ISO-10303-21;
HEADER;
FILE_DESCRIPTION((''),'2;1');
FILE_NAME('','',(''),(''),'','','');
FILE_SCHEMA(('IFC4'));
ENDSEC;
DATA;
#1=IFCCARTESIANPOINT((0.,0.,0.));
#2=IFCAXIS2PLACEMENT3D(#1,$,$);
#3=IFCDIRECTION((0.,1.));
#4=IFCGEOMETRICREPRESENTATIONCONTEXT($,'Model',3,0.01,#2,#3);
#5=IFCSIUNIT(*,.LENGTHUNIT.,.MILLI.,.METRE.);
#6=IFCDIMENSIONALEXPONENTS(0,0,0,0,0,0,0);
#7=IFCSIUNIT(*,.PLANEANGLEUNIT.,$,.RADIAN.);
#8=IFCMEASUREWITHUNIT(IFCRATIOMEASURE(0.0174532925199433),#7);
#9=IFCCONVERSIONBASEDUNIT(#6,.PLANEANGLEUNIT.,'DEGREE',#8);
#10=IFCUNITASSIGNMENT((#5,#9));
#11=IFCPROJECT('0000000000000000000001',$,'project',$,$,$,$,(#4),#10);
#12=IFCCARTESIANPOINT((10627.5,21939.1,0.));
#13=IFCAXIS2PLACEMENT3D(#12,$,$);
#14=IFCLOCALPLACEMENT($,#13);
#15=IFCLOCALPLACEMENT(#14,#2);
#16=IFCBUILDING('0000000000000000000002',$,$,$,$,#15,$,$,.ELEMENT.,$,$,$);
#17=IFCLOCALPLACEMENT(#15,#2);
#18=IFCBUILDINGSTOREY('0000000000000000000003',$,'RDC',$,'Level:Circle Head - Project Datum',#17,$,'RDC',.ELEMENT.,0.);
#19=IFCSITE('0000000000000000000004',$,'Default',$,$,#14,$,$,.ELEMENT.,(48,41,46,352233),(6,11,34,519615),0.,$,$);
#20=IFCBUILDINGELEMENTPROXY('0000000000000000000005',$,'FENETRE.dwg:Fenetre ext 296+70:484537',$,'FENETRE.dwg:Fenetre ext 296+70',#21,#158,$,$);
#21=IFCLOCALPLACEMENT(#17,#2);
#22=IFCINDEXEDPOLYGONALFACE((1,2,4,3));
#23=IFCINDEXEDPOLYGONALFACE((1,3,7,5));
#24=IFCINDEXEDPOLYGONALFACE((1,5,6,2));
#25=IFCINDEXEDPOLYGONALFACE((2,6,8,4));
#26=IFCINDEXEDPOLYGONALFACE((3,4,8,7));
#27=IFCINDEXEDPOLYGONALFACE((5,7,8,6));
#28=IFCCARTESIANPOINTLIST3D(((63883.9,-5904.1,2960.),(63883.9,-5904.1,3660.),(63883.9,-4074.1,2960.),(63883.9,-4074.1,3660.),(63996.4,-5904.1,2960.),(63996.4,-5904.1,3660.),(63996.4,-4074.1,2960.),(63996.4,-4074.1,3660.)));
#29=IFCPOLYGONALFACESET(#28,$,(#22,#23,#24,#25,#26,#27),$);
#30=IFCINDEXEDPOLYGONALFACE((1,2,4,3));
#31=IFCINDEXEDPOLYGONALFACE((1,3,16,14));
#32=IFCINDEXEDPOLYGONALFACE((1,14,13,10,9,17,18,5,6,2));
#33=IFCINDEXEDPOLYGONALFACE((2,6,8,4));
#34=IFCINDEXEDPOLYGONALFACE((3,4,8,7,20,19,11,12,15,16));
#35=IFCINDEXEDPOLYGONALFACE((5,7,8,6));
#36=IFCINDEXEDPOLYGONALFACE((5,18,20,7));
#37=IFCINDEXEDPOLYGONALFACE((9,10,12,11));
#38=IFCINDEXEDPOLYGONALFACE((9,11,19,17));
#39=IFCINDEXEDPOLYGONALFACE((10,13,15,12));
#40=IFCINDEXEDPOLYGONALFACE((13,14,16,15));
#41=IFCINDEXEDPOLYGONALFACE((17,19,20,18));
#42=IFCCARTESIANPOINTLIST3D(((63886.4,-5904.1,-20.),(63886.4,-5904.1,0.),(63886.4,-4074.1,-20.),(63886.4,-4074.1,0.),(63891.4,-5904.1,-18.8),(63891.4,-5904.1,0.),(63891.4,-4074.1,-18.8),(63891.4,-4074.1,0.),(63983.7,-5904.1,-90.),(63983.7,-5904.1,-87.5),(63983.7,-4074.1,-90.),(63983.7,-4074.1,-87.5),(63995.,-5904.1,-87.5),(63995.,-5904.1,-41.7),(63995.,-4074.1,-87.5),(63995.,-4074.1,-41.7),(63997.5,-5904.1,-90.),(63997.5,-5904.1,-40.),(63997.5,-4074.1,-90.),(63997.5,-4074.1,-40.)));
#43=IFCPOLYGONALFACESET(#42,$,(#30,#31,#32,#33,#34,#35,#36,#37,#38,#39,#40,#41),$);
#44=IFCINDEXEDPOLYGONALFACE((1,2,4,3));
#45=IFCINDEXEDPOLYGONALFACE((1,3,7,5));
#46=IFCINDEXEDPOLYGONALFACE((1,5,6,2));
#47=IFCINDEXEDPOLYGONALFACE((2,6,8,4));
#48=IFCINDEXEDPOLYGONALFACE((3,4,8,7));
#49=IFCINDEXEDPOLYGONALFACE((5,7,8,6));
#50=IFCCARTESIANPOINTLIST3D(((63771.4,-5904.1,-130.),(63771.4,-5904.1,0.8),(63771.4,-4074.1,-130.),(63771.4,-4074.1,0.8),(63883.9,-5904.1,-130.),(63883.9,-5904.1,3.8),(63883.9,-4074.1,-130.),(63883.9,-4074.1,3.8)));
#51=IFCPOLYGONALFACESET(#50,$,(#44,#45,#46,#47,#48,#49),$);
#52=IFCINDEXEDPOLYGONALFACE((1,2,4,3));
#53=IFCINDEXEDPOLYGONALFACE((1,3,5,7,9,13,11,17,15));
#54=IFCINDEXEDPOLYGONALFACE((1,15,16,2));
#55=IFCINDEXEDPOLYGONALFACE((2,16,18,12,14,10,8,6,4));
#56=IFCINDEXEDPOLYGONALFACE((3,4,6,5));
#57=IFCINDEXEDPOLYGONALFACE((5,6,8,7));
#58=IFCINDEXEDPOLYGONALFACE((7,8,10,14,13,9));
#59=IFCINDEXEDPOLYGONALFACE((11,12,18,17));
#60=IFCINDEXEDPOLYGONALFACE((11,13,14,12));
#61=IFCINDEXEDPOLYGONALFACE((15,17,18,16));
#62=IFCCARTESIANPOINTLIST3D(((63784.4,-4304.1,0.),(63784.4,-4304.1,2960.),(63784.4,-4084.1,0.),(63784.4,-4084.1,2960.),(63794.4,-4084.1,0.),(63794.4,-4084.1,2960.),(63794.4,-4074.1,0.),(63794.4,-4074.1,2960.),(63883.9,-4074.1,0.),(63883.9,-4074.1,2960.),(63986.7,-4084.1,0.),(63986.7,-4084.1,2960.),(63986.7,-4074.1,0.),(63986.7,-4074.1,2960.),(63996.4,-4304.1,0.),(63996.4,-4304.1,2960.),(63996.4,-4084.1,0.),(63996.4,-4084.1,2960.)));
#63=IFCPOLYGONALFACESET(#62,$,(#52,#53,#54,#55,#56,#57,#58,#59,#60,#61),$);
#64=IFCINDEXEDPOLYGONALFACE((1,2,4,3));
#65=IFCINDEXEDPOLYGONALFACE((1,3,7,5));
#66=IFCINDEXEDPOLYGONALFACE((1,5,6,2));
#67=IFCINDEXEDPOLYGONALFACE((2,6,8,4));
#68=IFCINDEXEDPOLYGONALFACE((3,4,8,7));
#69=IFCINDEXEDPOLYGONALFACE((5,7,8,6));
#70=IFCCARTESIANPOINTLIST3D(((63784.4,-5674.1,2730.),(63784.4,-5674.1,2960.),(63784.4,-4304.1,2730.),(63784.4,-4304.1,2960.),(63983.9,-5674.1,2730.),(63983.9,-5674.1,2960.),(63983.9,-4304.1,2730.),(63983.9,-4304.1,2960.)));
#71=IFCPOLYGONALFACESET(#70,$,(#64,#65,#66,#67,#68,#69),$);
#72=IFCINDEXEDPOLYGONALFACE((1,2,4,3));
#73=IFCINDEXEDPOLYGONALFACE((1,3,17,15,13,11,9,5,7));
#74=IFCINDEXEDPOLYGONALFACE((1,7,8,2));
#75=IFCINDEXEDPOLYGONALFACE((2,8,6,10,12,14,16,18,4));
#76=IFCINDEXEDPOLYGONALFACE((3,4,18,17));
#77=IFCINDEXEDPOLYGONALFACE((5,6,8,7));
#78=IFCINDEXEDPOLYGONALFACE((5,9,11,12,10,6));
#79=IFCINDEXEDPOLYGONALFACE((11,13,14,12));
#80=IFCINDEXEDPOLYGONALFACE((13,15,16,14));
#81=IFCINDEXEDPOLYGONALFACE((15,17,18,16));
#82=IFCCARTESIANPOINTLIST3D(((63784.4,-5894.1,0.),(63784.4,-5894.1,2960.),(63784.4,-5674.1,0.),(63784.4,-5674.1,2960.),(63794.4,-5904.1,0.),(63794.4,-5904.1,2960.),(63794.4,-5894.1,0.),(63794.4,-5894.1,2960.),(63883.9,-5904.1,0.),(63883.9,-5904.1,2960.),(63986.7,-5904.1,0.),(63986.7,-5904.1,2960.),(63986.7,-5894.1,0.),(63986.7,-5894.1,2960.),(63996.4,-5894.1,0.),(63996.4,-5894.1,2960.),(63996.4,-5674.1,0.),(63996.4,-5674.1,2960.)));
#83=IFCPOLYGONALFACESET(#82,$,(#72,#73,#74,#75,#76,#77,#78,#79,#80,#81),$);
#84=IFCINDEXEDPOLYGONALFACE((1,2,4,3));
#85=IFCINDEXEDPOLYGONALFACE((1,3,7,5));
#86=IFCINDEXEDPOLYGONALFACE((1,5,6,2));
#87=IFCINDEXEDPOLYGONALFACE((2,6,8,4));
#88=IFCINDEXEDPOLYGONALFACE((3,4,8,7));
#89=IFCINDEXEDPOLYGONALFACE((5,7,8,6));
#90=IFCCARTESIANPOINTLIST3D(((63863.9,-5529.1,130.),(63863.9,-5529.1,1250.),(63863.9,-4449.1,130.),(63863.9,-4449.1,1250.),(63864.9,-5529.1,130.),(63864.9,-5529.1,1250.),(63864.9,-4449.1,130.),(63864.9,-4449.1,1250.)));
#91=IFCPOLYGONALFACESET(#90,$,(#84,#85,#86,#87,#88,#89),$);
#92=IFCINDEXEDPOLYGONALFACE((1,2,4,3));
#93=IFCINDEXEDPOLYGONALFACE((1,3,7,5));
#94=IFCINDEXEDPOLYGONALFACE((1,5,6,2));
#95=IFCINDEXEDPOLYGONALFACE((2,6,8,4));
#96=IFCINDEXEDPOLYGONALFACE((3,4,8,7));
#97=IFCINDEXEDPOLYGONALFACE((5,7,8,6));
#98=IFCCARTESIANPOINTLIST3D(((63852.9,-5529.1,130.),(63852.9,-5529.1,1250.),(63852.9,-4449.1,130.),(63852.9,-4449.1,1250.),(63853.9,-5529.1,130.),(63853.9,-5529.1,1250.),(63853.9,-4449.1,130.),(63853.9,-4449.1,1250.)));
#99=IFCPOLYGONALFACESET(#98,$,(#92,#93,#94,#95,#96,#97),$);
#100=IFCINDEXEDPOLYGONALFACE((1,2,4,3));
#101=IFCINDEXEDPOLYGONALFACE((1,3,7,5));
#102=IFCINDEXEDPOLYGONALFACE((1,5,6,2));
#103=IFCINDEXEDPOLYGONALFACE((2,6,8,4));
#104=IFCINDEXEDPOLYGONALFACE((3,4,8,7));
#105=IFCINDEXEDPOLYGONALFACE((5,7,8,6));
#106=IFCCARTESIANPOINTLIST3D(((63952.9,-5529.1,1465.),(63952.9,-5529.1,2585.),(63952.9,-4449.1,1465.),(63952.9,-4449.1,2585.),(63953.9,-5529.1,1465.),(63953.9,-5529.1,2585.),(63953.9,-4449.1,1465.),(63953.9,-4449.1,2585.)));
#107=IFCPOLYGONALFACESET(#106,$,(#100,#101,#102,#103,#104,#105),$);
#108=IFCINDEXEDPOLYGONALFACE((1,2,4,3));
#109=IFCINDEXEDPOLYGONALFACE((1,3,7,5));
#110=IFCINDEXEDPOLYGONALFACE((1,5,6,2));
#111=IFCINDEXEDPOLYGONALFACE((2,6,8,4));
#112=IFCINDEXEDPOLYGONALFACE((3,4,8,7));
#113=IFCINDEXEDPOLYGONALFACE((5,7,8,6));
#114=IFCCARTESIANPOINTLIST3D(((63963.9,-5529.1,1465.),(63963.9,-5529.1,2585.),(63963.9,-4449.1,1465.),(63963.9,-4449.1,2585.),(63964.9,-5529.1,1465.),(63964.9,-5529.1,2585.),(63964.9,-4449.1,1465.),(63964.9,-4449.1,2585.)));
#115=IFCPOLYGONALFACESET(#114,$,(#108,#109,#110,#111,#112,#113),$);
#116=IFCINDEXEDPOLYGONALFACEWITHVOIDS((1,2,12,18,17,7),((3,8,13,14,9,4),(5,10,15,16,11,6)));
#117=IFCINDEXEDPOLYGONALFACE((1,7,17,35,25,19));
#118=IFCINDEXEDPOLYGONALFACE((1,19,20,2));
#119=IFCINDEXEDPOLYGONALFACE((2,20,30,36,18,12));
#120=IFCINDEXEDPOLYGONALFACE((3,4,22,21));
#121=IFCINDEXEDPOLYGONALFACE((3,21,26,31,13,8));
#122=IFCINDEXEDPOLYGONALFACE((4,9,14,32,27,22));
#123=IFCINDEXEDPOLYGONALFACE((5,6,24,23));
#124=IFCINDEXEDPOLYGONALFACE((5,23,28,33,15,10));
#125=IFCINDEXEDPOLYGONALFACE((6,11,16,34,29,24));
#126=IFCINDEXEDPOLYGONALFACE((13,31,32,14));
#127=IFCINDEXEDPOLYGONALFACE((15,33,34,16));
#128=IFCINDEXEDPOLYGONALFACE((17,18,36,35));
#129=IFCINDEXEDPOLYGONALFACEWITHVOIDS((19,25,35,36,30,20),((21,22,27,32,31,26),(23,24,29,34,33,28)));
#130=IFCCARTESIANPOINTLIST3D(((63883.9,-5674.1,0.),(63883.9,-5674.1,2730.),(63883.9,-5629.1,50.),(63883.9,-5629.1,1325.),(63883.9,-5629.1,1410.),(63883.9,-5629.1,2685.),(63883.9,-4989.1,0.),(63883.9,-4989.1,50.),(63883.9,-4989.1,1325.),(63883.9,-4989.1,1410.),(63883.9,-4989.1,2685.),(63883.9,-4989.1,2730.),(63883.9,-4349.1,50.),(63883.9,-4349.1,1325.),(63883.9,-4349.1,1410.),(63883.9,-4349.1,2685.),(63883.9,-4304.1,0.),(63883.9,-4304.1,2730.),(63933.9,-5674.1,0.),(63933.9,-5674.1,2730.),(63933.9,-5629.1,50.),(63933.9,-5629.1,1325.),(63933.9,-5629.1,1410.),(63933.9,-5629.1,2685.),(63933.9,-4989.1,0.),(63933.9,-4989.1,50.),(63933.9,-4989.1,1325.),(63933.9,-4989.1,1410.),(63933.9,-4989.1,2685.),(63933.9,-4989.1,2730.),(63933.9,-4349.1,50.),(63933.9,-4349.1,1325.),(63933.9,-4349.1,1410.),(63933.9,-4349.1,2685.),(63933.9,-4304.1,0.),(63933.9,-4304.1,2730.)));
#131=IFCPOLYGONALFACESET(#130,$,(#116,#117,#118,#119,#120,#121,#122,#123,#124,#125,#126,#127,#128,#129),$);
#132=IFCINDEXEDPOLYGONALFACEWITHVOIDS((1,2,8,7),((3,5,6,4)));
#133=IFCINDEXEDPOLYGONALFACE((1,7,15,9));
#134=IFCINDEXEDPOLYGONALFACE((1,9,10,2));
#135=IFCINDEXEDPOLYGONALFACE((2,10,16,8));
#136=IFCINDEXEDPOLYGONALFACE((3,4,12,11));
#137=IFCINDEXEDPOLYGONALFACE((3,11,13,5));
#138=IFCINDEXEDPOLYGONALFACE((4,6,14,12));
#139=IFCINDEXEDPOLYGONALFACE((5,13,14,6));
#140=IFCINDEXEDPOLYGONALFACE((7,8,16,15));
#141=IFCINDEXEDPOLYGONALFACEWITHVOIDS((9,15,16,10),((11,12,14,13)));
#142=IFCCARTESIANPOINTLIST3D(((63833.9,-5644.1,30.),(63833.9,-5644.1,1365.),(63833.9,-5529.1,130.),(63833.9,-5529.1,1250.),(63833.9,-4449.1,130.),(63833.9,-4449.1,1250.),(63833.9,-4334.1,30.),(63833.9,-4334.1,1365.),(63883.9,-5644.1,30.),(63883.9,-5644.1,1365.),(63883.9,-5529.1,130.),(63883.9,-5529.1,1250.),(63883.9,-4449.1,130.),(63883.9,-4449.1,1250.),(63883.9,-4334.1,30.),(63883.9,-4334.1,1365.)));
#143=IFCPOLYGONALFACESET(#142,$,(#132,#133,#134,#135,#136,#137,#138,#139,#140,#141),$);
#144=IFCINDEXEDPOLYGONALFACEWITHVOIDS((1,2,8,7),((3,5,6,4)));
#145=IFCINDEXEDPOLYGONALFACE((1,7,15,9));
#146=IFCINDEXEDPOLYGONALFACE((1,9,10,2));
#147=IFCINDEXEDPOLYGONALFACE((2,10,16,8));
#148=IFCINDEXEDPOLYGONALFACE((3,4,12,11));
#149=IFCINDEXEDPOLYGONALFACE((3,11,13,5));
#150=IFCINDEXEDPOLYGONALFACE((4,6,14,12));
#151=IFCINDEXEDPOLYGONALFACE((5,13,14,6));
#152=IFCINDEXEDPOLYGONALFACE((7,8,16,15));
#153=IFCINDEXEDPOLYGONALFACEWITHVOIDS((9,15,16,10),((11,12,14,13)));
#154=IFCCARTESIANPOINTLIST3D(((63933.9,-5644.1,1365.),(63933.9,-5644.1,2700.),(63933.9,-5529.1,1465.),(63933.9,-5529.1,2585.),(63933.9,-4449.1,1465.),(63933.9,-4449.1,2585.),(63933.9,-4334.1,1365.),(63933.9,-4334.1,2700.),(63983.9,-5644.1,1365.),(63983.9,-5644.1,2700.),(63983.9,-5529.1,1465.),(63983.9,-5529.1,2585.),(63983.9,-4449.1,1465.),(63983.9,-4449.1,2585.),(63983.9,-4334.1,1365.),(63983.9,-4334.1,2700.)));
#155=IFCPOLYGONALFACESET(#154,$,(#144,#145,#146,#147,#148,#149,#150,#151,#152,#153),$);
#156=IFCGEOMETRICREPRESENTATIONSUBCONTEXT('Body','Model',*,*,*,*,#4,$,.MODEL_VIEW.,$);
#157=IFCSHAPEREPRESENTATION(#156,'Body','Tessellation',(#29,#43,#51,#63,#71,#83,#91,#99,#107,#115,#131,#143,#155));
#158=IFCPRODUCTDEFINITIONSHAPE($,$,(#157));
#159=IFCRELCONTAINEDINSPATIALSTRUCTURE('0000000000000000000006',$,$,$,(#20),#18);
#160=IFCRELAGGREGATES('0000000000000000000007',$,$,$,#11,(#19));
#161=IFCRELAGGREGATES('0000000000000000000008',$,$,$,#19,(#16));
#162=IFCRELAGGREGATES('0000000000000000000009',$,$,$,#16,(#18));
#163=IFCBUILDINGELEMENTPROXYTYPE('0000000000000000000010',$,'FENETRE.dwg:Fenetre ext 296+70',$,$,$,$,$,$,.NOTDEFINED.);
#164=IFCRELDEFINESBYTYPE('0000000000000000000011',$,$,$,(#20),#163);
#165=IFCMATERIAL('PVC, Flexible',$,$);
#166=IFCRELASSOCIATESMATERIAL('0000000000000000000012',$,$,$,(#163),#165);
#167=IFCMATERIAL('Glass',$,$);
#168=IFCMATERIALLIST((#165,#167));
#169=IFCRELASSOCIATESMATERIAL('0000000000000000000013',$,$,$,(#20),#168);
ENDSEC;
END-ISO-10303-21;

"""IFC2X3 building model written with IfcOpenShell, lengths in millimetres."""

from ifc_helpers import new_model, entity, si_unit, converted_unit, direction, frame, frame_2d, origin, origin_2d_with_axis, place, context, subcontext, project, spatial, polyline, rectangle, outline, extrude, source, transform, mapped, material, material_list, type_object, type_shapes, element, save


model = new_model("IFC2X3")

# Units and contexts
model_context = context("Model", 3, precision=0.01, world=origin(), true_north=direction((0.0, 1.0)))
body_context = subcontext(model_context, "Body", "Model", "MODEL_VIEW")
ifc_project = project(units=[si_unit("LENGTHUNIT", "METRE", prefix="MILLI"), converted_unit("PLANEANGLEUNIT", "DEGREE", entity("IfcRatioMeasure", 0.0174532925199433), si_unit("PLANEANGLEUNIT", "RADIAN"), dimensions=[0, 0, 0, 0, 0, 0, 0])], contexts=[model_context])

# Site, building, storey
site_placement = place(None, frame((10627.5, 21939.1, 0.0)))
site = spatial("IfcSite", under=ifc_project, at=site_placement, Name="Default", CompositionType="ELEMENT", RefLatitude=(48, 41, 46, 352233), RefLongitude=(6, 11, 34, 519615), RefElevation=0.0)
building_placement = place(site_placement, origin())
building = spatial("IfcBuilding", under=site, at=building_placement, CompositionType="ELEMENT")
storey_placement = place(building_placement, origin())
storey = spatial("IfcBuildingStorey", under=building, at=storey_placement, Name="RDC", ObjectType="Level:Circle Head - Project Datum", LongName="RDC", CompositionType="ELEMENT", Elevation=0.0)

# Building element proxy
ifc_material_1 = material(Name="PVC, Flexible")
ifc_material_2 = material(Name="Glass")
building_element_proxy_type_1 = type_object("IfcBuildingElementProxyType", Name="FENETRE.dwg:Fenetre ext 296+70", PredefinedType="NOTDEFINED", material=ifc_material_1)
shared_shape_1 = source(origin(), body_context, "Body", "SweptSolid", [
    extrude(rectangle(XDim=112.5, YDim=1830.0, at=origin_2d_with_axis()), frame((-10.4, -56.3, 2960.0), z_axis=(0.0, 0.0, 1.0), x_axis=(0.0, 1.0, 0.0)), (0.0, 0.0, 1.0), 700.0),
    extrude(outline(polyline([(27.5, -64.4), (47.5, -64.4), (47.5, -59.4), (28.8, -59.4), (7.5, 46.7), (-42.5, 46.7), (-42.5, 32.9), (-40.0, 32.9), (-40.0, 44.2), (5.8, 44.2), (27.5, -64.4)])), frame((-925.4, -66.9, -47.5), z_axis=(1.0, 0.0, 0.0), x_axis=(0.0, 0.0, 1.0)), (0.0, 0.0, 1.0), 1830.0),
    extrude(outline(polyline([(-54.5, -66.1), (58.0, -66.1), (54.5, 67.6), (-58.0, 64.6), (-54.5, -66.1)])), frame((-925.4, 56.3, -63.8), z_axis=(1.0, 0.0, 0.0), x_axis=(0.0, -0.999645, 0.02665)), (0.0, 0.0, 1.0), 1830.0),
    extrude(outline(polyline([(-97.0, -55.6), (5.9, -55.6), (95.4, -55.6), (95.4, -45.6), (105.4, -45.6), (105.4, 174.4), (-106.6, 174.4), (-106.6, -45.6), (-97.0, -45.6), (-97.0, -55.6)])), frame((849.0, -5.9, 0.0), z_axis=(0.0, 0.0, 1.0), x_axis=(0.0, 1.0, 0.0)), (0.0, 0.0, 1.0), 2960.0),
    extrude(rectangle(XDim=1370.0, YDim=199.5, at=origin_2d_with_axis()), frame((-10.4, -0.3, 2730.0), z_axis=(0.0, 0.0, 1.0), x_axis=(-1.0, 0.0, 0.0)), (0.0, 0.0, 1.0), 230.0),
    extrude(outline(polyline([(-55.6, 97.0), (-55.6, -5.9), (-55.6, -95.4), (-45.6, -95.4), (-45.6, -105.4), (174.4, -105.4), (174.4, 106.6), (-45.6, 106.6), (-45.6, 97.0), (-55.6, 97.0)])), frame((-869.9, -5.9, 0.0), z_axis=(0.0, 0.0, -1.0), x_axis=(1.0, 0.0, 0.0)), (0.0, 0.0, -1.0), 2960.0),
    extrude(rectangle(XDim=1080.0, YDim=1.0, at=origin_2d_with_axis()), frame((-10.4, 19.5, 130.0), z_axis=(0.0, 0.0, 1.0), x_axis=(-1.0, 0.0, 0.0)), (0.0, 0.0, 1.0), 1120.0),
    extrude(rectangle(XDim=1080.0, YDim=1.0, at=origin_2d_with_axis()), frame((-10.4, 30.5, 130.0), z_axis=(0.0, 0.0, 1.0), x_axis=(-1.0, 0.0, 0.0)), (0.0, 0.0, 1.0), 1120.0),
    extrude(rectangle(XDim=1080.0, YDim=1.0, at=frame_2d((0.0, 0.0), x_axis=(1.0, 0.0))), frame((-10.4, -69.5, 1465.0), z_axis=(0.0, 0.0, 1.0), x_axis=(-1.0, 0.0, 0.0)), (0.0, 0.0, 1.0), 1120.0),
    extrude(rectangle(XDim=1080.0, YDim=1.0, at=frame_2d((0.0, 0.0), x_axis=(1.0, 0.0))), frame((-10.4, -80.5, 1465.0), z_axis=(0.0, 0.0, 1.0), x_axis=(-1.0, 0.0, 0.0)), (0.0, 0.0, 1.0), 1120.0),
    extrude(outline(polyline([(-685.0, -1365.0), (0.0, -1365.0), (685.0, -1365.0), (685.0, 1365.0), (0.0, 1365.0), (-685.0, 1365.0), (-685.0, -1365.0)]), holes=[polyline([(-640.0, -1320.0), (-640.0, -45.0), (0.0, -45.0), (640.0, -45.0), (640.0, -1320.0), (0.0, -1320.0), (-640.0, -1320.0)]), polyline([(-640.0, 40.0), (-640.0, 1315.0), (0.0, 1315.0), (640.0, 1315.0), (640.0, 40.0), (0.0, 40.0), (-640.0, 40.0)])]), frame((-10.4, -50.0, 1365.0), z_axis=(0.0, 1.0, 0.0), x_axis=(1.0, 0.0, 0.0)), (0.0, 0.0, 1.0), 50.0),
    extrude(outline(polyline([(-655.0, -667.5), (655.0, -667.5), (655.0, 667.5), (-655.0, 667.5), (-655.0, -667.5)]), holes=[polyline([(-540.0, 552.5), (540.0, 552.5), (540.0, -567.5), (-540.0, -567.5), (-540.0, 552.5)])]), frame((-10.4, 0.0, 697.5), z_axis=(0.0, 1.0, 0.0), x_axis=(-1.0, 0.0, 0.0)), (0.0, 0.0, 1.0), 50.0),
    extrude(outline(polyline([(-655.0, -667.5), (655.0, -667.5), (655.0, 667.5), (-655.0, 667.5), (-655.0, -667.5)]), holes=[polyline([(-540.0, 552.5), (540.0, 552.5), (540.0, -567.5), (-540.0, -567.5), (-540.0, 552.5)])]), frame((-10.4, -100.0, 2032.5), z_axis=(0.0, 1.0, 0.0), x_axis=(-1.0, 0.0, 0.0)), (0.0, 0.0, 1.0), 50.0),
])
type_shapes(building_element_proxy_type_1, [shared_shape_1])
ifc_material_list_1 = material_list([ifc_material_1, ifc_material_2])
proxy_1_placement = place(storey_placement, frame((63883.9, -4978.7, 0.0), z_axis=(0.0, 0.0, 1.0), x_axis=(0.0, 1.0, 0.0)))
element("IfcBuildingElementProxy", 1, at=proxy_1_placement, inside=storey, type_object=building_element_proxy_type_1, material=ifc_material_list_1, Name="FENETRE.dwg:Fenetre ext 296+70:484537", ObjectType="FENETRE.dwg:Fenetre ext 296+70", context=body_context, shape_type="MappedRepresentation", body=[
    mapped(shared_shape_1, transform((0.0, 0.0, 0.0), scale=1.0)),
])

save(model, "model.ifc")
